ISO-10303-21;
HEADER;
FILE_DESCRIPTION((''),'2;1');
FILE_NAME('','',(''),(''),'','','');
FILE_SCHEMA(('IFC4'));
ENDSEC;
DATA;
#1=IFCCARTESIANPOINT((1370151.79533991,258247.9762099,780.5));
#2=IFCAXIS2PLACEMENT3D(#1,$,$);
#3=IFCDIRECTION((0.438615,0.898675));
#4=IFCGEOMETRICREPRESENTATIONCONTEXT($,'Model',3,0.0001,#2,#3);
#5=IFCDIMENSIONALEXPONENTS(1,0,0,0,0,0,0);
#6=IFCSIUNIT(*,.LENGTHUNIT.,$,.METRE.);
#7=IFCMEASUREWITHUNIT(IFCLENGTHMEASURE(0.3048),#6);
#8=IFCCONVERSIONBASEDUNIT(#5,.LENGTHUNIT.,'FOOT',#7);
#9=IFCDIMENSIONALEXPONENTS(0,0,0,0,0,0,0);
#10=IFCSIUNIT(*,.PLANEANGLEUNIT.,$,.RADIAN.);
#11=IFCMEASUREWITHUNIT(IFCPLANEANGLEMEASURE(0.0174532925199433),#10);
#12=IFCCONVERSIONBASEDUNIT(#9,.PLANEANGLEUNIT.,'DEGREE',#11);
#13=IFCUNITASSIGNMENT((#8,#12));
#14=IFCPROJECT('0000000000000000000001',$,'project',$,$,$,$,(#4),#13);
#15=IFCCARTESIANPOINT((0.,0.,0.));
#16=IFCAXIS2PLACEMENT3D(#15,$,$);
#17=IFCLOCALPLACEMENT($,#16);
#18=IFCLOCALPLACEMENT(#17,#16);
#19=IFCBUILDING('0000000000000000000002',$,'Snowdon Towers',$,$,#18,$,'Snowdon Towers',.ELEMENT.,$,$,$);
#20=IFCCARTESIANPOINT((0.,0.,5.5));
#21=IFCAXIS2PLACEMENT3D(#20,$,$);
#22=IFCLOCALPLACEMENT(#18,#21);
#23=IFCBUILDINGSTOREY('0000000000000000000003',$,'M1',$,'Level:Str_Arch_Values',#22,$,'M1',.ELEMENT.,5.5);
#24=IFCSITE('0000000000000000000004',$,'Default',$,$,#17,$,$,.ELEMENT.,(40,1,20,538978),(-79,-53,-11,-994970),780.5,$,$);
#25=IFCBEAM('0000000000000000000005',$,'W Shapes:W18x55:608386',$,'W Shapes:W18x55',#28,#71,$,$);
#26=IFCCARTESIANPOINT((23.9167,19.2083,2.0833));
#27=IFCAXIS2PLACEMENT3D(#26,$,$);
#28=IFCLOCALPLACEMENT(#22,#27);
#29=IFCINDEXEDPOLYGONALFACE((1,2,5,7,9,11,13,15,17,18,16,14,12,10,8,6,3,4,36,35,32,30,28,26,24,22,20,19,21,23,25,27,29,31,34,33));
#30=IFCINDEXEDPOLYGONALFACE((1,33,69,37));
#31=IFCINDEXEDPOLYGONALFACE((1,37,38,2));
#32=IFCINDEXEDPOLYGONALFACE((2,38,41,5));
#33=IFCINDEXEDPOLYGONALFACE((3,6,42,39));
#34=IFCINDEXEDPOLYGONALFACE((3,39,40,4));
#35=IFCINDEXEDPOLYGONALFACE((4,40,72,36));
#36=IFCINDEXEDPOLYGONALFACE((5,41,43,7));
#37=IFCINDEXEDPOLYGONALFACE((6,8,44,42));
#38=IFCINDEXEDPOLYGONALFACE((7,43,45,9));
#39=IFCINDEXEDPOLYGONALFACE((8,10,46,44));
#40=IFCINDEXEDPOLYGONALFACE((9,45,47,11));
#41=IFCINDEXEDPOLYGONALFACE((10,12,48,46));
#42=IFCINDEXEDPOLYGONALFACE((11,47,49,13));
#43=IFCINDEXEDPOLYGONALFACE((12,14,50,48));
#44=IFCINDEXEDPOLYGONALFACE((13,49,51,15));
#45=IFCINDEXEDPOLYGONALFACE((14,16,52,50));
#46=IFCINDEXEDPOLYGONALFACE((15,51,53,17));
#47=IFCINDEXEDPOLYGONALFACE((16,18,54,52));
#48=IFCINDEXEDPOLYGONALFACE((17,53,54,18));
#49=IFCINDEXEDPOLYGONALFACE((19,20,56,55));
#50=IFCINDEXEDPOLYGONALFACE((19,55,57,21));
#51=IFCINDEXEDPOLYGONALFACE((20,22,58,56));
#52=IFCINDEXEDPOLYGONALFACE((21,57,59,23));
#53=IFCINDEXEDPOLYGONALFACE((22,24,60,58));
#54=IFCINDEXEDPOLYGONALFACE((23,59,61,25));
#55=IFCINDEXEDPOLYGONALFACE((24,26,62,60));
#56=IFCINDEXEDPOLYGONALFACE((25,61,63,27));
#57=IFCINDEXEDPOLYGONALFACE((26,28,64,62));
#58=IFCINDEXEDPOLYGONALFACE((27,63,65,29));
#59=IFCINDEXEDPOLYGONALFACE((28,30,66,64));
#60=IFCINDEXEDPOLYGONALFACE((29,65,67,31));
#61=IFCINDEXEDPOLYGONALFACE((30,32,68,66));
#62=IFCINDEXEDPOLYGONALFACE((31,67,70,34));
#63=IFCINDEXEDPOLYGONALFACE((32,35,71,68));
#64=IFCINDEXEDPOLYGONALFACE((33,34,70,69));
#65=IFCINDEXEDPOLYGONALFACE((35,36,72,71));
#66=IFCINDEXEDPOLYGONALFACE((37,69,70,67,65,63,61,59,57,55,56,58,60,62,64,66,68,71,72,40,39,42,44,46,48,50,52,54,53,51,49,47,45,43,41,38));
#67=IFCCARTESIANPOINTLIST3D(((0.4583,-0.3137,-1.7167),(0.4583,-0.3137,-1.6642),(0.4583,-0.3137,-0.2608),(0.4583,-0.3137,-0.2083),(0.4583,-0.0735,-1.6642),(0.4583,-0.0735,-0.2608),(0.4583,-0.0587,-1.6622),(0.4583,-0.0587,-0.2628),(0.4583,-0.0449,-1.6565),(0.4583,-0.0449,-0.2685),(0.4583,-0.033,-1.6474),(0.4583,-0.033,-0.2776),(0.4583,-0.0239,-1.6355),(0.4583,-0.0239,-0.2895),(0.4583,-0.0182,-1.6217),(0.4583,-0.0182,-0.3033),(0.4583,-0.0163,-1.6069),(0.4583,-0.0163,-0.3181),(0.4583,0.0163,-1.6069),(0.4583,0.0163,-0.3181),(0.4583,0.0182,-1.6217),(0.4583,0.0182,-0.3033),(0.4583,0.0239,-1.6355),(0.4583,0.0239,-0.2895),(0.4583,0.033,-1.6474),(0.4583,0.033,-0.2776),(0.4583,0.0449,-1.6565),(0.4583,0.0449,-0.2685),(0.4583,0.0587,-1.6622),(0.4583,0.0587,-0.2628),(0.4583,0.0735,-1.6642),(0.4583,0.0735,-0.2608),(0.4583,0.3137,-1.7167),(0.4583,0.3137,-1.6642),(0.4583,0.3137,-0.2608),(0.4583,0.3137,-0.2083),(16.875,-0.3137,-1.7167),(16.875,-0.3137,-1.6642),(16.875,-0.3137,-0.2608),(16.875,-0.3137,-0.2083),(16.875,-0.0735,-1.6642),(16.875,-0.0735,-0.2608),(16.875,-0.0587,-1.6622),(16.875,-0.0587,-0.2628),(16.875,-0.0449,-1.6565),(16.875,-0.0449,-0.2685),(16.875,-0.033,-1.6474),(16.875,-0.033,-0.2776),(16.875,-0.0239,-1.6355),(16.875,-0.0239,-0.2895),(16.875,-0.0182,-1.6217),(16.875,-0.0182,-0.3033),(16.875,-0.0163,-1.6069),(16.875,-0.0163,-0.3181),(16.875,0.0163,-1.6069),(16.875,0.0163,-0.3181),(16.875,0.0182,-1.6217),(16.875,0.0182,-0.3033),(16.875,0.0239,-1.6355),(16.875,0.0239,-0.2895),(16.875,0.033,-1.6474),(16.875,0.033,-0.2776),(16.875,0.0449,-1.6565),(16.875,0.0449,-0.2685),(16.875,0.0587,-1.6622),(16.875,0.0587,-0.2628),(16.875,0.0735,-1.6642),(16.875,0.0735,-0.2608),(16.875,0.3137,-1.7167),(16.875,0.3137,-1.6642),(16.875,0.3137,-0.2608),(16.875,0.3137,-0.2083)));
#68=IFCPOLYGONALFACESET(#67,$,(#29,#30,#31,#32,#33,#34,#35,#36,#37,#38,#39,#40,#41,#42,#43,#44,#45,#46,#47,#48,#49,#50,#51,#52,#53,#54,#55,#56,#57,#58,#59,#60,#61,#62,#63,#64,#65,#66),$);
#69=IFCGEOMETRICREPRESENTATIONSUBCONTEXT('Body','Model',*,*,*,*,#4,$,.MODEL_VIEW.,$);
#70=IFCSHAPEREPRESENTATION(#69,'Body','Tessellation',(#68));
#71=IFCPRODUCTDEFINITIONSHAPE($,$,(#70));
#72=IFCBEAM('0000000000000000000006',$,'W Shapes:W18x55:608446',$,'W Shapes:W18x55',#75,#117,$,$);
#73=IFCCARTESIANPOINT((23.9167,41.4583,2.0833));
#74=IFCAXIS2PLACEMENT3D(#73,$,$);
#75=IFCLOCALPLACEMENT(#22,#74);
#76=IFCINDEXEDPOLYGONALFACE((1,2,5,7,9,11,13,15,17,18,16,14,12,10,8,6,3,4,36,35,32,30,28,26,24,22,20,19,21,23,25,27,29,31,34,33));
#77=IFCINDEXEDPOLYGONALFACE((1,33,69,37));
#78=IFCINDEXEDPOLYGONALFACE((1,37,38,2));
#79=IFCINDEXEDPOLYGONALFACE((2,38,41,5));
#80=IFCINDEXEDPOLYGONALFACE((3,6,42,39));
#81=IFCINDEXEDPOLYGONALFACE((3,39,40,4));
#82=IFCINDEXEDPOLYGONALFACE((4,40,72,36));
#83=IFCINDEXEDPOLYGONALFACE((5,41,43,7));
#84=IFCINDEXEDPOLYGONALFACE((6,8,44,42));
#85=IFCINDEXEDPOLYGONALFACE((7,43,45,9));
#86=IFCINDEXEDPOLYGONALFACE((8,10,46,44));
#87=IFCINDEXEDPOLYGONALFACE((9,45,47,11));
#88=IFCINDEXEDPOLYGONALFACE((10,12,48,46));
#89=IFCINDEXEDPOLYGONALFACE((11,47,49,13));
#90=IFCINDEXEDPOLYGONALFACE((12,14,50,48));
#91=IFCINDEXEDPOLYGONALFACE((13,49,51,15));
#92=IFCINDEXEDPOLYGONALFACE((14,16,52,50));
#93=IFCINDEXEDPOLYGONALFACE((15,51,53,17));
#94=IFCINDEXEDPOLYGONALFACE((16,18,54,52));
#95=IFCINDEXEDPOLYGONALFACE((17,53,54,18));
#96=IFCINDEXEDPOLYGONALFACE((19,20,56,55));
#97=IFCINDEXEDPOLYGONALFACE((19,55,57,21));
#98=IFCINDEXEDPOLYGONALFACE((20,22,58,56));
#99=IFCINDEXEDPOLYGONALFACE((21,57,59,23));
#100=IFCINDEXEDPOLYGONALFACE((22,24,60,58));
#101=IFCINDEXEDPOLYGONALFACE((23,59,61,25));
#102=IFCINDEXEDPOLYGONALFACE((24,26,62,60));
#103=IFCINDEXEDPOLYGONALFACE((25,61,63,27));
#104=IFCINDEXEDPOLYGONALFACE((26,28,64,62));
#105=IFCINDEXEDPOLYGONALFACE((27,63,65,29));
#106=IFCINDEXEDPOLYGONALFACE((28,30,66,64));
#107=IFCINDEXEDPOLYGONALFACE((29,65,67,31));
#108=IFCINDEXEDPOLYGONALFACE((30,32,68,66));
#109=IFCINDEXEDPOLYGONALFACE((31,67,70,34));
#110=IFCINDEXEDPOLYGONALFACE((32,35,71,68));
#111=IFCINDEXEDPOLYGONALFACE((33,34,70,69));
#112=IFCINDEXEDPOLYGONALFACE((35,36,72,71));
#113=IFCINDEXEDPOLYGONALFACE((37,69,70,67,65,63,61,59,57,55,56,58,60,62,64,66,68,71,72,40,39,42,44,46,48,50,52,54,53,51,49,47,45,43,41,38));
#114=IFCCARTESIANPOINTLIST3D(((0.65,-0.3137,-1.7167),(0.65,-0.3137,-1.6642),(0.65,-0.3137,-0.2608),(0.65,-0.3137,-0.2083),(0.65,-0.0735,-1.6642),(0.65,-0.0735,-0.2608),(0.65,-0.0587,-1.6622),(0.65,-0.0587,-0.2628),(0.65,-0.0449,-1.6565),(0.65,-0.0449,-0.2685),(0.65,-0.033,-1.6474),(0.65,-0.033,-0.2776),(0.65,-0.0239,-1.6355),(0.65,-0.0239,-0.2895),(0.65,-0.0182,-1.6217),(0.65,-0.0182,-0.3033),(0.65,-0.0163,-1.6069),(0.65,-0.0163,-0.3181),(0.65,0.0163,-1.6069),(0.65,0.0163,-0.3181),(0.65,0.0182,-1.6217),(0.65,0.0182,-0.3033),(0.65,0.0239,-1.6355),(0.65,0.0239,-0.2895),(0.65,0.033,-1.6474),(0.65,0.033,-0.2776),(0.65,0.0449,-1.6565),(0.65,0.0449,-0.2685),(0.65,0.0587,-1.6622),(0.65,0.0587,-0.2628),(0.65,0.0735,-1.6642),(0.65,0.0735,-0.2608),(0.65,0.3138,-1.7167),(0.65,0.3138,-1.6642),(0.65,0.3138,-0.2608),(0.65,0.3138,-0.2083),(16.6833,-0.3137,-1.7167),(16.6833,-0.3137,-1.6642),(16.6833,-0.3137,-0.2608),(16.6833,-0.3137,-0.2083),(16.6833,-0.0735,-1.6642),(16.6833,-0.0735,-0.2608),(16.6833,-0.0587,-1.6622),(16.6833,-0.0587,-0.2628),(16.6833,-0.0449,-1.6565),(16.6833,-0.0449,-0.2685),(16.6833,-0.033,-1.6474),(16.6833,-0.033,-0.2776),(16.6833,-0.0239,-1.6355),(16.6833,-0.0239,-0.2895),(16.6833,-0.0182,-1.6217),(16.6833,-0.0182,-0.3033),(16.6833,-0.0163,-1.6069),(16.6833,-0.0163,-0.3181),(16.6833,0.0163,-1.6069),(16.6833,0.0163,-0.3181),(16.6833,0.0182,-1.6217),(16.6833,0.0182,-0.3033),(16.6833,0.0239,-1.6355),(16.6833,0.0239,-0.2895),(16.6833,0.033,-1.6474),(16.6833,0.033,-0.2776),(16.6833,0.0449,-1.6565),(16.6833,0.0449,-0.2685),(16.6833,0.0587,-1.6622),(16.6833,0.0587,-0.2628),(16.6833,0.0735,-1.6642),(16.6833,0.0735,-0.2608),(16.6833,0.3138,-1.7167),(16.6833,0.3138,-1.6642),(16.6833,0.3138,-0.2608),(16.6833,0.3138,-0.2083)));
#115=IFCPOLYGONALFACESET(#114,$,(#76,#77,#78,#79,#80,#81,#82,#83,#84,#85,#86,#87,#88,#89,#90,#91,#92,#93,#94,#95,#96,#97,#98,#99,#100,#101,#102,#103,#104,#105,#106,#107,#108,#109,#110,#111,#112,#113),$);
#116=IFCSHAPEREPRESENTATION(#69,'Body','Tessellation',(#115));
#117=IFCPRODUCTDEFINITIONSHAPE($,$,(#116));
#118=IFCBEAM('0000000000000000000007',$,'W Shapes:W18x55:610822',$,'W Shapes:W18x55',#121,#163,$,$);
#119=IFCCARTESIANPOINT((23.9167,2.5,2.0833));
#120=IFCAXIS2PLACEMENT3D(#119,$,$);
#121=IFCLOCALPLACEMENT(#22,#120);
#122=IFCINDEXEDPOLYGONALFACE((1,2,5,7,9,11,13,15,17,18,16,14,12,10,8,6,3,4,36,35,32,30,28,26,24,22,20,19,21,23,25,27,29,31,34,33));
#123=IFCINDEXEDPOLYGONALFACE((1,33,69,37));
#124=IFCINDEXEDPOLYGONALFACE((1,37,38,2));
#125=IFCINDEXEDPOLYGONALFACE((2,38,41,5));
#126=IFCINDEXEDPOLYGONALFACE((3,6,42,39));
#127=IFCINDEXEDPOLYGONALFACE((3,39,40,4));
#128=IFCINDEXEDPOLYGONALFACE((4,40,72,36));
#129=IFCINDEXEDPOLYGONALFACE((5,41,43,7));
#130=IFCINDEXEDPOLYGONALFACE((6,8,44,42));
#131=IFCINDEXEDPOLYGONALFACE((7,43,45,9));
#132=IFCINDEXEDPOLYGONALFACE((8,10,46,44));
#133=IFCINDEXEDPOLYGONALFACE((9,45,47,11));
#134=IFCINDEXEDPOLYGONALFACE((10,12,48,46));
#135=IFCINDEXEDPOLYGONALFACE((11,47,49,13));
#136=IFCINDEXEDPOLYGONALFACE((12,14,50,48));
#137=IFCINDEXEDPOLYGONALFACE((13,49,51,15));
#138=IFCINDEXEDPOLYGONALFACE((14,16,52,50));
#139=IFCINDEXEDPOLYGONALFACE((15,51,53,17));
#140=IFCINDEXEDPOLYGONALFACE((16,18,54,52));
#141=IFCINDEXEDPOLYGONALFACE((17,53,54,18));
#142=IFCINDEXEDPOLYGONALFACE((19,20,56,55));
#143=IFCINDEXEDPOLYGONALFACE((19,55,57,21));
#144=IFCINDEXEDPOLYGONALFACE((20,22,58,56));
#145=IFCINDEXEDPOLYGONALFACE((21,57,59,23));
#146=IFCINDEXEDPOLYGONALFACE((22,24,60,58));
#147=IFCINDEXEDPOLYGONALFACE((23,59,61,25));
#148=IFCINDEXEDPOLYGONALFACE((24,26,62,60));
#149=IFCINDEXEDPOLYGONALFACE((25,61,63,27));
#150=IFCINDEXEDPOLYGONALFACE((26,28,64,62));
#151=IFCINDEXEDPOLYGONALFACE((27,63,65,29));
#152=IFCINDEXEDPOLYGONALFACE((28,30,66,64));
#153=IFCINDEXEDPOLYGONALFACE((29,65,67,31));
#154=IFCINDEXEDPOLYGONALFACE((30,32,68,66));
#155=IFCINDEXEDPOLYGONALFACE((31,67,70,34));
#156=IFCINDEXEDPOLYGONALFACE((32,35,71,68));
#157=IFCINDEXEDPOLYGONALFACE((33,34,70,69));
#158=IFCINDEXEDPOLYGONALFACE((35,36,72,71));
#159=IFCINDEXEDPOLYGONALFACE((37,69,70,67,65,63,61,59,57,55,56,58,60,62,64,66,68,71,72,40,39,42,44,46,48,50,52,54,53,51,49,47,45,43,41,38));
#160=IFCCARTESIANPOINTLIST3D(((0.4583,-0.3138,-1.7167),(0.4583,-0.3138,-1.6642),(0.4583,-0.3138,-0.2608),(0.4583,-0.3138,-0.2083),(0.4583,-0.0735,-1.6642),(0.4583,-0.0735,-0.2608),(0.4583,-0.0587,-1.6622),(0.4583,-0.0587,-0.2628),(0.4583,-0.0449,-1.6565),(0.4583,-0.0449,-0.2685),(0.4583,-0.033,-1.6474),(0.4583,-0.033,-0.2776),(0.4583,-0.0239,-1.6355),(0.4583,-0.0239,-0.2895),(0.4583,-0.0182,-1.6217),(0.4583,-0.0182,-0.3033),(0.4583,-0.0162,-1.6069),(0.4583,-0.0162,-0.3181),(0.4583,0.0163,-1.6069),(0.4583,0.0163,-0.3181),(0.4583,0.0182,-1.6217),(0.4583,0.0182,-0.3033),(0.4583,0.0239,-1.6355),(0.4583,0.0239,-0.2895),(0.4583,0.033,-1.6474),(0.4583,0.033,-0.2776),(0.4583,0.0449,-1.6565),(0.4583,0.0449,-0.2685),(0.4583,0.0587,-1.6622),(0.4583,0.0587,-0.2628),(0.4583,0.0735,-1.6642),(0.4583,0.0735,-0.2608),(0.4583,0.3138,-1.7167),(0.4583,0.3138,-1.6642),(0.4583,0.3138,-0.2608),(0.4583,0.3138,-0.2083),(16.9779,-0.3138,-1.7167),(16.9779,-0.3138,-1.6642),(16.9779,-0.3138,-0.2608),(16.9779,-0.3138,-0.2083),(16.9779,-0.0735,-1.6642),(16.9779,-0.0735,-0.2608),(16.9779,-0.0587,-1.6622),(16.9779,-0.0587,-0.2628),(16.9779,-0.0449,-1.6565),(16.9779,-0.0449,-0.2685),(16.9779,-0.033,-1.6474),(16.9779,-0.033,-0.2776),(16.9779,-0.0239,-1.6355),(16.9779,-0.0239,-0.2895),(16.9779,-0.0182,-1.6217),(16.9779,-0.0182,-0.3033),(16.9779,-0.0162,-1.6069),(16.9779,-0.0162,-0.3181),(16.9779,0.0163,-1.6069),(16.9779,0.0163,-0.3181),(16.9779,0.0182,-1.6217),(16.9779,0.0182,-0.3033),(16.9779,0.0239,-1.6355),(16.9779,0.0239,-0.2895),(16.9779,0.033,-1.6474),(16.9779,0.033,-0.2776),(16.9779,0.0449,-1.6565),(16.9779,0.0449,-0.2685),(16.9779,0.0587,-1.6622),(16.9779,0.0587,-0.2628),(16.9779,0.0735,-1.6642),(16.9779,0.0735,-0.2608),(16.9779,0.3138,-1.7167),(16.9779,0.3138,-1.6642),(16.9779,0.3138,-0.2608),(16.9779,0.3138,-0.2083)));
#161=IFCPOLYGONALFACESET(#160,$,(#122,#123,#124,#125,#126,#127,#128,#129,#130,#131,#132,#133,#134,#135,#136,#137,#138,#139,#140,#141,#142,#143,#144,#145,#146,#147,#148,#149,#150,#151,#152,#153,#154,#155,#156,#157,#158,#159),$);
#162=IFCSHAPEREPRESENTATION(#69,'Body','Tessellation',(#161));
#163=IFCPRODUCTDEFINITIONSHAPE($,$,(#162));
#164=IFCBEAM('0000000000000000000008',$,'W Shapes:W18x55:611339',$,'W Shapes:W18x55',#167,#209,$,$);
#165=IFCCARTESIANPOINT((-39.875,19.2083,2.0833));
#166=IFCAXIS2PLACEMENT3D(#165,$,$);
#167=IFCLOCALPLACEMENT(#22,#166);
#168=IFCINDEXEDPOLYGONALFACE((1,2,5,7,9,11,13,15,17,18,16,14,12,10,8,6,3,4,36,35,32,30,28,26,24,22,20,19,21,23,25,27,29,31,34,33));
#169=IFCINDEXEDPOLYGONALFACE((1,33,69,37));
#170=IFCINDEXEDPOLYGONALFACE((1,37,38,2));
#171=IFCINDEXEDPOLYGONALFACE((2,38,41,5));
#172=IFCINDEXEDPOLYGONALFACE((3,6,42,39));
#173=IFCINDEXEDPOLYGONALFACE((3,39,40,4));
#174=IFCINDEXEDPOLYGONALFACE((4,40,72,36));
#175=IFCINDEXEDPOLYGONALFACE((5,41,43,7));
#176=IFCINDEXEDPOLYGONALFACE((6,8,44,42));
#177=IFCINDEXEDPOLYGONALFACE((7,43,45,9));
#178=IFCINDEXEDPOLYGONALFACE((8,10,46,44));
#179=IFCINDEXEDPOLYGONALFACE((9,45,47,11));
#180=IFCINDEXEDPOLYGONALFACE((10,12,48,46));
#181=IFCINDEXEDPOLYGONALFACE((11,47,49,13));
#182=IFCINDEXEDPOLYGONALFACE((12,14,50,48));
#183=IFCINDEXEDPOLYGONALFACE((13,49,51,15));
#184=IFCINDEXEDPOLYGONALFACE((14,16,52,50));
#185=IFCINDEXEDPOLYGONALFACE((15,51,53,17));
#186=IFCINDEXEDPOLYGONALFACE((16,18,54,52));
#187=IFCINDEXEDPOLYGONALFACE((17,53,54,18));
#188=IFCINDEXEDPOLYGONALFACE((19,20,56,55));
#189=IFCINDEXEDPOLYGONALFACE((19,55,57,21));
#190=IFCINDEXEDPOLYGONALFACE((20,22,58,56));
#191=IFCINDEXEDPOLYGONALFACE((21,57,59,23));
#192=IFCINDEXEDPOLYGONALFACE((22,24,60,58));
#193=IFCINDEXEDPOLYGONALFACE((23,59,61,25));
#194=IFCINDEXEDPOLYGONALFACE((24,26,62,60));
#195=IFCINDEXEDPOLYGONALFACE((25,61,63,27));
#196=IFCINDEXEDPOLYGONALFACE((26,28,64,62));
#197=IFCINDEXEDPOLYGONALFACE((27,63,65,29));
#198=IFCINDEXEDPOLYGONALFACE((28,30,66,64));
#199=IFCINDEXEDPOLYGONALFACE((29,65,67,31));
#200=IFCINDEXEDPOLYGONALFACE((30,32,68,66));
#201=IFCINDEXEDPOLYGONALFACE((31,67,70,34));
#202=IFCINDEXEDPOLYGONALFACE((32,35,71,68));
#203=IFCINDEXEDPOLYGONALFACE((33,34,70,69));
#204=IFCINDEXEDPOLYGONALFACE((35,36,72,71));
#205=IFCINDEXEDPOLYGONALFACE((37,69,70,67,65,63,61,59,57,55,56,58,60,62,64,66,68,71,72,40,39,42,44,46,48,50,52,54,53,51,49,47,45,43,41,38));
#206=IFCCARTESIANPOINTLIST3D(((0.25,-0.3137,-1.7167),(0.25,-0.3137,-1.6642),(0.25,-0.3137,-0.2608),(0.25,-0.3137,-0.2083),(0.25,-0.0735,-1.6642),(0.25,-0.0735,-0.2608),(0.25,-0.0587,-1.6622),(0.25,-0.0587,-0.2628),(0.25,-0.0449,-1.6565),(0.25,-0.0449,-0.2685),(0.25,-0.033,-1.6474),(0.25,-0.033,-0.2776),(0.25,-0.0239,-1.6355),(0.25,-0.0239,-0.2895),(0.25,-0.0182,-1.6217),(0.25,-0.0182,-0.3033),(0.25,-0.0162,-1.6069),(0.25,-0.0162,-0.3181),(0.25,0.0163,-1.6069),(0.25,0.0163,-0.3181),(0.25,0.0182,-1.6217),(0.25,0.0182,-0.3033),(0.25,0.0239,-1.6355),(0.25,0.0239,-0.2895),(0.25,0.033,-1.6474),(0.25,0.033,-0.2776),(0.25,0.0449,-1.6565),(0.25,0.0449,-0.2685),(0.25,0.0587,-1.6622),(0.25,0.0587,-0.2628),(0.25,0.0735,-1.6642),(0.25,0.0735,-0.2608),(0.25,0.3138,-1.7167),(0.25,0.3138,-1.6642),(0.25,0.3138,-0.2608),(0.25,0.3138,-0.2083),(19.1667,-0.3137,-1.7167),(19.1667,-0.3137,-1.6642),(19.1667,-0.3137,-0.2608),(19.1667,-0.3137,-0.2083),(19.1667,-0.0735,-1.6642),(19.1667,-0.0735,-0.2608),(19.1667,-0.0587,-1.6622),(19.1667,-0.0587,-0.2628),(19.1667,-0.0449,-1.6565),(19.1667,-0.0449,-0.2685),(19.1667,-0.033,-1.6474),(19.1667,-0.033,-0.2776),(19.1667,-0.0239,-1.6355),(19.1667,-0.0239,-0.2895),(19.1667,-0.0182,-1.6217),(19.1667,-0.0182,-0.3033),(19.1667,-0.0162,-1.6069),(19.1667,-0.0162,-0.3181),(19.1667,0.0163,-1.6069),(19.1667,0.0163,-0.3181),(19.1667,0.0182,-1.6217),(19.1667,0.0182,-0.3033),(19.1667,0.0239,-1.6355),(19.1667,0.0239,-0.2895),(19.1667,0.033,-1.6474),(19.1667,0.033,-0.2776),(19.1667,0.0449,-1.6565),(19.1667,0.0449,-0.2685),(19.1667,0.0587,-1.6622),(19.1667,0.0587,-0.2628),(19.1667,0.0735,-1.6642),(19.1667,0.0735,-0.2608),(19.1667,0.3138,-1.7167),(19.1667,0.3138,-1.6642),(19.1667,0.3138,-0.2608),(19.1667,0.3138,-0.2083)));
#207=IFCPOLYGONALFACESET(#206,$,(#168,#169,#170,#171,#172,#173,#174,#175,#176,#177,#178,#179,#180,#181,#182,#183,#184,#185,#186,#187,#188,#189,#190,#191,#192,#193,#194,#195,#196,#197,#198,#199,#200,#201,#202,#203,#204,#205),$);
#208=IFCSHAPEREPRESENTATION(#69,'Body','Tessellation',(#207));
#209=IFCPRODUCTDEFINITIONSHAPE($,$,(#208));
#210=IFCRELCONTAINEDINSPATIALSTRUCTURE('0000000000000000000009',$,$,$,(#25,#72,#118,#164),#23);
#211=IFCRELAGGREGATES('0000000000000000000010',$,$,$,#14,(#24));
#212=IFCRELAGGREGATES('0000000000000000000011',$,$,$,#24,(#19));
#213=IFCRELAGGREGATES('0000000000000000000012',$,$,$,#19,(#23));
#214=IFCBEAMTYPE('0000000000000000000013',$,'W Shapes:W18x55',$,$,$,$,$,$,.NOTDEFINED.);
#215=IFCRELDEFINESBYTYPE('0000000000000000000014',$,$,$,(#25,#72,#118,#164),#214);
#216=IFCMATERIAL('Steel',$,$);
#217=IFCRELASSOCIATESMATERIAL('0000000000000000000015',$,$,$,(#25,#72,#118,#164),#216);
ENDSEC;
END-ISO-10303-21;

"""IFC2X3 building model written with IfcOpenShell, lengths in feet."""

from ifc_helpers import new_model, entity, si_unit, converted_unit, direction, frame, frame_2d, origin, place, context, subcontext, project, spatial, i_section, extrude, material, type_object, element, save


model = new_model("IFC2X3")

# Units and contexts
model_context = context("Model", 3, precision=0.0001, world=frame((1370151.79533991, 258247.9762099, 780.5)), true_north=direction((0.438615, 0.898675)))
body_context = subcontext(model_context, "Body", "Model", "MODEL_VIEW")
ifc_project = project(units=[converted_unit("LENGTHUNIT", "FOOT", entity("IfcLengthMeasure", 0.3048), si_unit("LENGTHUNIT", "METRE"), dimensions=[1, 0, 0, 0, 0, 0, 0]), converted_unit("PLANEANGLEUNIT", "DEGREE", entity("IfcPlaneAngleMeasure", 0.0174532925199433), si_unit("PLANEANGLEUNIT", "RADIAN"), dimensions=[0, 0, 0, 0, 0, 0, 0])], contexts=[model_context])

# Site, building, storey
site_placement = place(None, origin())
site = spatial("IfcSite", under=ifc_project, at=site_placement, Name="Default", CompositionType="ELEMENT", RefLatitude=(40, 1, 20, 538978), RefLongitude=(-79, -53, -11, -994970), RefElevation=780.5)
building_placement = place(site_placement, origin())
building = spatial("IfcBuilding", under=site, at=building_placement, Name="Snowdon Towers", LongName="Snowdon Towers", CompositionType="ELEMENT")
storey_placement = place(building_placement, frame((0.0, 0.0, 5.5)))
storey = spatial("IfcBuildingStorey", under=building, at=storey_placement, Name="M1", ObjectType="Level:Str_Arch_Values", LongName="M1", CompositionType="ELEMENT", Elevation=5.5)

# Beams
ifc_material_1 = material(Name="Steel")
beam_type_1 = type_object("IfcBeamType", Name="W Shapes:W18x55", PredefinedType="NOTDEFINED")
beam_1_placement = place(storey_placement, frame((23.9167, 19.2083, 2.0833)))
element("IfcBeam", 1, at=beam_1_placement, inside=storey, type_object=beam_type_1, material=ifc_material_1, Name="W Shapes:W18x55:608386", ObjectType="W Shapes:W18x55", context=body_context, shape_type="SweptSolid", body=[
    extrude(i_section(OverallWidth=0.6275, OverallDepth=1.5083, WebThickness=0.0325, FlangeThickness=0.0525, FilletRadius=0.0573, at=frame_2d((0.0, 0.0), x_axis=(0.0, 1.0))), frame((0.4583, 0.0, -0.9625), z_axis=(1.0, 0.0, 0.0), x_axis=(0.0, 0.0, -1.0)), (0.0, 0.0, 1.0), 16.4167),
])
beam_2_placement = place(storey_placement, frame((23.9167, 41.4583, 2.0833)))
element("IfcBeam", 2, at=beam_2_placement, inside=storey, type_object=beam_type_1, material=ifc_material_1, Name="W Shapes:W18x55:608446", ObjectType="W Shapes:W18x55", context=body_context, shape_type="SweptSolid", body=[
    extrude(i_section(OverallWidth=0.6275, OverallDepth=1.5083, WebThickness=0.0325, FlangeThickness=0.0525, FilletRadius=0.0573, at=frame_2d((0.0, 0.0), x_axis=(0.0, 1.0))), frame((0.65, 0.0, -0.9625), z_axis=(1.0, 0.0, 0.0), x_axis=(0.0, 0.0, -1.0)), (0.0, 0.0, 1.0), 16.0333),
])
beam_3_placement = place(storey_placement, frame((23.9167, 2.5, 2.0833)))
element("IfcBeam", 3, at=beam_3_placement, inside=storey, type_object=beam_type_1, material=ifc_material_1, Name="W Shapes:W18x55:610822", ObjectType="W Shapes:W18x55", context=body_context, shape_type="SweptSolid", body=[
    extrude(i_section(OverallWidth=0.6275, OverallDepth=1.5083, WebThickness=0.0325, FlangeThickness=0.0525, FilletRadius=0.0573, at=frame_2d((0.0, 0.0), x_axis=(0.0, 1.0))), frame((0.4583, 0.0, -0.9625), z_axis=(1.0, 0.0, 0.0), x_axis=(0.0, 0.0, -1.0)), (0.0, 0.0, 1.0), 16.5196),
])
beam_4_placement = place(storey_placement, frame((-39.875, 19.2083, 2.0833)))
element("IfcBeam", 4, at=beam_4_placement, inside=storey, type_object=beam_type_1, material=ifc_material_1, Name="W Shapes:W18x55:611339", ObjectType="W Shapes:W18x55", context=body_context, shape_type="SweptSolid", body=[
    extrude(i_section(OverallWidth=0.6275, OverallDepth=1.5083, WebThickness=0.0325, FlangeThickness=0.0525, FilletRadius=0.0573, at=frame_2d((0.0, 0.0), x_axis=(0.0, 1.0))), frame((0.25, 0.0, -0.9625), z_axis=(1.0, 0.0, 0.0), x_axis=(0.0, 0.0, -1.0)), (0.0, 0.0, 1.0), 18.9167),
])

save(model, "model.ifc")
